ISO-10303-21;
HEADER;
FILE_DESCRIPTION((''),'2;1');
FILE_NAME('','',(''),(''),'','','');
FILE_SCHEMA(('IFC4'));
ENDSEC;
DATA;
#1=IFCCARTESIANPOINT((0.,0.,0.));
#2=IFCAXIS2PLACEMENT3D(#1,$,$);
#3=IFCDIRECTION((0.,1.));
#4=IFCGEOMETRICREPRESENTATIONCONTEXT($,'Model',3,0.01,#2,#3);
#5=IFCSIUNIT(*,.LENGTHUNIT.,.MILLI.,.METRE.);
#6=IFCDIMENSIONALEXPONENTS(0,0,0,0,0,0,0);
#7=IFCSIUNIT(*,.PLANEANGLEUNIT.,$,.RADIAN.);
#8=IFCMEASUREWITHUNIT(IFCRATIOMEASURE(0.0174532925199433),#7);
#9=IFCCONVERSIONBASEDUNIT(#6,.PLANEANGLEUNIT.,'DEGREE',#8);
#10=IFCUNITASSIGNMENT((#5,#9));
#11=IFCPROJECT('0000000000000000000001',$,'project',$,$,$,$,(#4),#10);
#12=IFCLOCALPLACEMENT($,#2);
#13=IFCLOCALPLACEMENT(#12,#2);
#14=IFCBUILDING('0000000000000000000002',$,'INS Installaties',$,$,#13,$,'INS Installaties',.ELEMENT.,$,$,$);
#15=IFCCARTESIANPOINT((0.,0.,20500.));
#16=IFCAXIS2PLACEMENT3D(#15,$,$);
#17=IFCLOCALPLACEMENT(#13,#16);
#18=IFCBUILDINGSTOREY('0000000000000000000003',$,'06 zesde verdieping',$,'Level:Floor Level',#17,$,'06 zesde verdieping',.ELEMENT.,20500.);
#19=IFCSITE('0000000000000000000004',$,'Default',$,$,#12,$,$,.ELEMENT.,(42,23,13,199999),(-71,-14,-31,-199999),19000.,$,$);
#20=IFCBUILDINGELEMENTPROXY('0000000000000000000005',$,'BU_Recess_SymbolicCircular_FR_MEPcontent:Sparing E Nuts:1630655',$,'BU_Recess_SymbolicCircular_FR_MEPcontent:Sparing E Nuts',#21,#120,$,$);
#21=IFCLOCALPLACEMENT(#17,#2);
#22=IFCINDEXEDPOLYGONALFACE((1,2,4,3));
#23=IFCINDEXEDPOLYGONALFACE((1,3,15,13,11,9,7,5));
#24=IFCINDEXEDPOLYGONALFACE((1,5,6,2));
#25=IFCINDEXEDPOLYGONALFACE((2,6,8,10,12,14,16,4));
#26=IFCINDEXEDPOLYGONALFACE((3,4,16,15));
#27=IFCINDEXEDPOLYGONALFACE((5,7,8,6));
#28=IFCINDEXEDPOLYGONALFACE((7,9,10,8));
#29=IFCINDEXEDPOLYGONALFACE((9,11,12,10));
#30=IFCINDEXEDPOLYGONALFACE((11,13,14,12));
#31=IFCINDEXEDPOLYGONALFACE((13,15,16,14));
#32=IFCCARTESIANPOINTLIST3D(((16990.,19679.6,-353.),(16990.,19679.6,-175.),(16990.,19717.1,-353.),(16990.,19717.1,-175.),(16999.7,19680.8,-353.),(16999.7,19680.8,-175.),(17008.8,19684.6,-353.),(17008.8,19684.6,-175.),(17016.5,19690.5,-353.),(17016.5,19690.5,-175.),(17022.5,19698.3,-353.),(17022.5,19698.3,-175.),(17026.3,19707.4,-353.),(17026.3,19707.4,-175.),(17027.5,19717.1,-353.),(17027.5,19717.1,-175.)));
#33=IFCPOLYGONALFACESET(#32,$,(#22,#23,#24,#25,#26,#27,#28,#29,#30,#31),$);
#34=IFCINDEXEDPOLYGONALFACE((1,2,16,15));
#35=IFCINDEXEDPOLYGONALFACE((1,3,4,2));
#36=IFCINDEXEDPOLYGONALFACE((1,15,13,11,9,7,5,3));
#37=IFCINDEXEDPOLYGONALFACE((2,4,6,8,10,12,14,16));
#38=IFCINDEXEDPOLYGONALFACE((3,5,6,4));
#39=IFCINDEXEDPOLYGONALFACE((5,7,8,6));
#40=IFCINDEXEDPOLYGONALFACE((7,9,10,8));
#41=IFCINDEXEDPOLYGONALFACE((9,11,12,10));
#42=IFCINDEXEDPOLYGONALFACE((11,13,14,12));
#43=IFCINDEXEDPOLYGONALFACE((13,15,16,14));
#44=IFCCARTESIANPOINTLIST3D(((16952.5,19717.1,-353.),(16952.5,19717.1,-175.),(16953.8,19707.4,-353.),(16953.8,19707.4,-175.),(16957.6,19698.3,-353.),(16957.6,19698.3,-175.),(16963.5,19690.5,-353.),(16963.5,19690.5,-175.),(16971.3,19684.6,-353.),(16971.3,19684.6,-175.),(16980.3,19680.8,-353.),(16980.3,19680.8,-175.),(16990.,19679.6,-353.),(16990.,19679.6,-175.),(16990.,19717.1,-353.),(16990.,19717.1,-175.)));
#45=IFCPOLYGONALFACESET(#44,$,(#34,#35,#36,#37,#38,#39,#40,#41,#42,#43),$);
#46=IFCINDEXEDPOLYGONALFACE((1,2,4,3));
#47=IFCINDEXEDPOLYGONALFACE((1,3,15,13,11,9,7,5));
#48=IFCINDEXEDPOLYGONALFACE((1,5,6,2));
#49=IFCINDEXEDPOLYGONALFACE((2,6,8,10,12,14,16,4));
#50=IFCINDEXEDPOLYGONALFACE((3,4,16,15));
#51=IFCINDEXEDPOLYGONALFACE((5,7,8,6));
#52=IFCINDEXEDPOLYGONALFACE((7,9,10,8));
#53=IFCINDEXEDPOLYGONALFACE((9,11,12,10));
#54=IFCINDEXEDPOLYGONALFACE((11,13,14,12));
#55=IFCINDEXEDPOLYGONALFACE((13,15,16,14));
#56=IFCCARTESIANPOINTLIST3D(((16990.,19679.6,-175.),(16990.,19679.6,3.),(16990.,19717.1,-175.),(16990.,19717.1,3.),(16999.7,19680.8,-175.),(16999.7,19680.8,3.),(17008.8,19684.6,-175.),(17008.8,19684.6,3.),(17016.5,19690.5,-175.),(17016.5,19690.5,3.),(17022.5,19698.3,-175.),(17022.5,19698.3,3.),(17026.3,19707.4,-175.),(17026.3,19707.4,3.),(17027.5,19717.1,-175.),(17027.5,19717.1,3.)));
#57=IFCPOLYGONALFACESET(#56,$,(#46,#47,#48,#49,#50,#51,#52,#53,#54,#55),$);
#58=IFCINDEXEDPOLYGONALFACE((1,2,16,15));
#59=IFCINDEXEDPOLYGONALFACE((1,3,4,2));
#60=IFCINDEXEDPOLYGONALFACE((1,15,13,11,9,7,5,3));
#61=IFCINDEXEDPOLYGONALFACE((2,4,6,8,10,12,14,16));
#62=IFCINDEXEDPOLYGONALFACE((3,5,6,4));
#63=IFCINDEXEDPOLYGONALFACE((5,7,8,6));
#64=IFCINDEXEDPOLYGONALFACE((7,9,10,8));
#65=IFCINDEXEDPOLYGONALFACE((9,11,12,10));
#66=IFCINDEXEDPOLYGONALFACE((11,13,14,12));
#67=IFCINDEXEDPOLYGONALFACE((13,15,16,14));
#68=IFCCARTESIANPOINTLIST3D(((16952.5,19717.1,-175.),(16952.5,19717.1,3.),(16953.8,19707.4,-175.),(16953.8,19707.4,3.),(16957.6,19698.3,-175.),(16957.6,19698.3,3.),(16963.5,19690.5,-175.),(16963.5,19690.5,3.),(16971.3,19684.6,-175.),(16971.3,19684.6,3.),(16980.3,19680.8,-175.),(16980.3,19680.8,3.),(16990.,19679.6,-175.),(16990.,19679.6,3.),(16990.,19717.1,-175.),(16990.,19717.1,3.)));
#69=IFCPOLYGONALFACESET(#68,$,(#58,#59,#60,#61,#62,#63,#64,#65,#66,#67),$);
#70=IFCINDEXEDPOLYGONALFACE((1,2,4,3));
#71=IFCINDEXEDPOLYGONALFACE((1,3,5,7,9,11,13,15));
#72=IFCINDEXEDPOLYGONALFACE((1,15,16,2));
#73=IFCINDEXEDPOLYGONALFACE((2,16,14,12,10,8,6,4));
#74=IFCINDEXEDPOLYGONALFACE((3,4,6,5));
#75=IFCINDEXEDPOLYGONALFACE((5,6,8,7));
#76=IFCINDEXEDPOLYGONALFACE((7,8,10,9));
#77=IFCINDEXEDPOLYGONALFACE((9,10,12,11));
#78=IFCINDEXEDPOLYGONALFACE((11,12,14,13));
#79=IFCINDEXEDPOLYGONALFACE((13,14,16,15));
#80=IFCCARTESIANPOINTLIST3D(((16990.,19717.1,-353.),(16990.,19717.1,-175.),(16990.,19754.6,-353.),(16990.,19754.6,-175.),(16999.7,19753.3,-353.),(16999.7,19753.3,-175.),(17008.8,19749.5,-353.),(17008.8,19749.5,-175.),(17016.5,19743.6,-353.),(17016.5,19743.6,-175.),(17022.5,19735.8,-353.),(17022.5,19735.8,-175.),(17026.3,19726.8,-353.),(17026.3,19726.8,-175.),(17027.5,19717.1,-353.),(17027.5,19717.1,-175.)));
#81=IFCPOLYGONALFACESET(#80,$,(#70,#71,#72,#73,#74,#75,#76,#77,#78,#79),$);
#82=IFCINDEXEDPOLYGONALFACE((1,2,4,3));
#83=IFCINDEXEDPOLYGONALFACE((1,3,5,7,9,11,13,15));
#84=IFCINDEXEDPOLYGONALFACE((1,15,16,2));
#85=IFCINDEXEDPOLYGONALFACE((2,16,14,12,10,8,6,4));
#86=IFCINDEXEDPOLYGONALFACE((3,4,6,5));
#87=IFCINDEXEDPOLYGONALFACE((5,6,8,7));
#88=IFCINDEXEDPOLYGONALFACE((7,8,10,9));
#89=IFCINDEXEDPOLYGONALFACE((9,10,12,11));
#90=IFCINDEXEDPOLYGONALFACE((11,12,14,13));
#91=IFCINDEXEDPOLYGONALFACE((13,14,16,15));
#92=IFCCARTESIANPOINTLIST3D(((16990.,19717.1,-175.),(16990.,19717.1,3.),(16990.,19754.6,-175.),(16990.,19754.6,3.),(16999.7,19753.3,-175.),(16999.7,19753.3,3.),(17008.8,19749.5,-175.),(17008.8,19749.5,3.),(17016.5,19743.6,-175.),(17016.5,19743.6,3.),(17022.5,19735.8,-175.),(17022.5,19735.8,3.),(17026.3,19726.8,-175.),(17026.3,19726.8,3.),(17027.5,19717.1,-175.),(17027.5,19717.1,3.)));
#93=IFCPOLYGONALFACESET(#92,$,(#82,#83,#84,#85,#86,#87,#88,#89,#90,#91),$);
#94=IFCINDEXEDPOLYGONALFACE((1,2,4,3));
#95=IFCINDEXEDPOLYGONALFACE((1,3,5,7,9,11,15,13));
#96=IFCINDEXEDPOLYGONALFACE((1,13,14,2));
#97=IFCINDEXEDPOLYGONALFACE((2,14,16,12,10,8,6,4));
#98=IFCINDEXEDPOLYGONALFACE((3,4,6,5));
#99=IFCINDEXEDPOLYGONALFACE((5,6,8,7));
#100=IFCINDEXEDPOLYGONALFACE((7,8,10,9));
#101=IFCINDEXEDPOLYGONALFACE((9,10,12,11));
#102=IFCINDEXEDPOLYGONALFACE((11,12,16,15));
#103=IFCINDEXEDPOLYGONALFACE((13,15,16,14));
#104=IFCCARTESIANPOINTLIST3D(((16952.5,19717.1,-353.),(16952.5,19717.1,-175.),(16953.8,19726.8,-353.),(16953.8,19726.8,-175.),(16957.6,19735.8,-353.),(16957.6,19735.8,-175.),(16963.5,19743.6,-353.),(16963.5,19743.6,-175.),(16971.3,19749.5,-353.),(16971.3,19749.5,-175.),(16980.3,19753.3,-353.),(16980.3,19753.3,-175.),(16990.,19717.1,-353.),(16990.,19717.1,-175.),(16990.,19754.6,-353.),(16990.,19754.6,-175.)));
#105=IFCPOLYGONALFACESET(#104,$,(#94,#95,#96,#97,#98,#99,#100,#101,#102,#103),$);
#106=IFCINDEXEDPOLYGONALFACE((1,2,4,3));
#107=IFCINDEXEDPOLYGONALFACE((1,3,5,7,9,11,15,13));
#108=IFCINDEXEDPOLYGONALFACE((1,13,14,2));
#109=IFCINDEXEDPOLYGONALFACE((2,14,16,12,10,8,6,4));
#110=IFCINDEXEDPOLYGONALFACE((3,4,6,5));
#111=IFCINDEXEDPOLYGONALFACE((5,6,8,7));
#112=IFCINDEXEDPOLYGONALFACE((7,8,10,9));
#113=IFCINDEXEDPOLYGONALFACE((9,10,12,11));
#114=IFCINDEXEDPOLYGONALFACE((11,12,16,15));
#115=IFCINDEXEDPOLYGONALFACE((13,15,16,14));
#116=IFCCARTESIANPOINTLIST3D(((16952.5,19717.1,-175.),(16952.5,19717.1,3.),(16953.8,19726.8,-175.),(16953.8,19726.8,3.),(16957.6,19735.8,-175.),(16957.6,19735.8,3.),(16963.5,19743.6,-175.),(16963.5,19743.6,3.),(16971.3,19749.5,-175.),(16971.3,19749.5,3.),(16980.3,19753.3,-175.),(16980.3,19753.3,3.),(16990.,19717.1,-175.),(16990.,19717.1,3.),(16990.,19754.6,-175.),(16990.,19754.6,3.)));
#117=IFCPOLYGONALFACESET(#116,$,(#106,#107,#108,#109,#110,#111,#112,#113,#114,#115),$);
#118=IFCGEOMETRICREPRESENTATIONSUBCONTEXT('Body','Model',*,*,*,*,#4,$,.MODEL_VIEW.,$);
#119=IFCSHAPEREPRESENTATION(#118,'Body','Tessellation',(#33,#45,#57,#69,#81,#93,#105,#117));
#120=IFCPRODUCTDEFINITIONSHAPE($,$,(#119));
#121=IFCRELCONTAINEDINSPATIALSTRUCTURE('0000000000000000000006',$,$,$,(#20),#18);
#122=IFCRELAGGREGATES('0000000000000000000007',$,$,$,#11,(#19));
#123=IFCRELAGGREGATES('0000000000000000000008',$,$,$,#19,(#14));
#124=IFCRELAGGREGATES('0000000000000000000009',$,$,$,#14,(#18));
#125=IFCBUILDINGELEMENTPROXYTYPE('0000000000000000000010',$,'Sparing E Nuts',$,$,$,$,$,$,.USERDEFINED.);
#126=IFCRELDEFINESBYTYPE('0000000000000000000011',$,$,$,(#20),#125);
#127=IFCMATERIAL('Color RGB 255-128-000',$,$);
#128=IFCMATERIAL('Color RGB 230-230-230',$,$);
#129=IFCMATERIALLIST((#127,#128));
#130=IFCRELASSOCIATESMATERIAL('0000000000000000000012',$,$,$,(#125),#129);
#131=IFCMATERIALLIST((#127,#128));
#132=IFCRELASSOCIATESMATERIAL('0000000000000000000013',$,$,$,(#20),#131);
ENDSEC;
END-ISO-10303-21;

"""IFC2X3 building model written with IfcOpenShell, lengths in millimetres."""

from ifc_helpers import new_model, entity, si_unit, converted_unit, direction, frame, frame_2d, origin, place, context, subcontext, project, spatial, polyline, circle_curve, parameter, trimmed, segment, composite_curve, outline, extrude, source, transform, mapped, material, material_list, type_object, type_shapes, element, save


model = new_model("IFC2X3")

# Units and contexts
model_context = context("Model", 3, precision=0.01, world=origin(), true_north=direction((0.0, 1.0)))
body_context = subcontext(model_context, "Body", "Model", "MODEL_VIEW")
ifc_project = project(units=[si_unit("LENGTHUNIT", "METRE", prefix="MILLI"), converted_unit("PLANEANGLEUNIT", "DEGREE", entity("IfcRatioMeasure", 0.0174532925199433), si_unit("PLANEANGLEUNIT", "RADIAN"), dimensions=[0, 0, 0, 0, 0, 0, 0])], contexts=[model_context])

# Site, building, storey
site_placement = place(None, origin())
site = spatial("IfcSite", under=ifc_project, at=site_placement, Name="Default", CompositionType="ELEMENT", RefLatitude=(42, 23, 13, 199999), RefLongitude=(-71, -14, -31, -199999), RefElevation=19000.0)
building_placement = place(site_placement, origin())
building = spatial("IfcBuilding", under=site, at=building_placement, Name="INS Installaties", LongName="INS Installaties", CompositionType="ELEMENT")
storey_placement = place(building_placement, frame((0.0, 0.0, 20500.0)))
storey = spatial("IfcBuildingStorey", under=building, at=storey_placement, Name="06 zesde verdieping", ObjectType="Level:Floor Level", LongName="06 zesde verdieping", CompositionType="ELEMENT", Elevation=20500.0)

# Building element proxy
ifc_material_1 = material(Name="Color RGB 255-128-000")
ifc_material_2 = material(Name="Color RGB 230-230-230")
ifc_material_list_1 = material_list([ifc_material_1, ifc_material_2])
ifc_material_list_2 = material_list([ifc_material_1, ifc_material_2])
building_element_proxy_type_1 = type_object("IfcBuildingElementProxyType", Name="Sparing E Nuts", PredefinedType="USERDEFINED", material=ifc_material_list_2)
shared_shape_1 = source(origin(), body_context, "Body", "SweptSolid", [
    extrude(outline(composite_curve([segment(polyline([(-25.0, -12.5), (12.5, -12.5)]), True, "CONTINUOUS"), segment(polyline([(12.5, -12.5), (12.5, 25.0)]), True, "CONTINUOUS"), segment(trimmed(circle_curve(frame_2d((12.5, -12.5), x_axis=(1.0, 0.0)), 37.5), [parameter(90.0)], [parameter(180.0)], True, "PARAMETER"), True, "CONTINUOUS")], self_intersect=False)), frame((12.5, -12.5, -353.0), z_axis=(0.0, 0.0, 1.0), x_axis=(-1.0, 0.0, 0.0)), (0.0, 0.0, 1.0), 178.0),
    extrude(outline(composite_curve([segment(trimmed(circle_curve(frame_2d((12.5, 12.5), x_axis=(1.0, 0.0)), 37.5), [parameter(180.0)], [parameter(270.0)], True, "PARAMETER"), True, "CONTINUOUS"), segment(polyline([(12.5, -25.0), (12.5, 12.5)]), True, "CONTINUOUS"), segment(polyline([(12.5, 12.5), (-25.0, 12.5)]), True, "CONTINUOUS")], self_intersect=False)), frame((-12.5, -12.5, -353.0)), (0.0, 0.0, 1.0), 178.0),
    extrude(outline(composite_curve([segment(polyline([(-25.0, -12.5), (12.5, -12.5)]), True, "CONTINUOUS"), segment(polyline([(12.5, -12.5), (12.5, 25.0)]), True, "CONTINUOUS"), segment(trimmed(circle_curve(frame_2d((12.5, -12.5), x_axis=(1.0, 0.0)), 37.5), [parameter(90.0)], [parameter(180.0)], True, "PARAMETER"), True, "CONTINUOUS")], self_intersect=False)), frame((12.5, -12.5, -175.0), z_axis=(0.0, 0.0, 1.0), x_axis=(-1.0, 0.0, 0.0)), (0.0, 0.0, 1.0), 178.0),
    extrude(outline(composite_curve([segment(trimmed(circle_curve(frame_2d((12.5, 12.5), x_axis=(1.0, 0.0)), 37.5), [parameter(180.0)], [parameter(270.0)], True, "PARAMETER"), True, "CONTINUOUS"), segment(polyline([(12.5, -25.0), (12.5, 12.5)]), True, "CONTINUOUS"), segment(polyline([(12.5, 12.5), (-25.0, 12.5)]), True, "CONTINUOUS")], self_intersect=False)), frame((-12.5, -12.5, -175.0)), (0.0, 0.0, 1.0), 178.0),
    extrude(outline(composite_curve([segment(trimmed(circle_curve(frame_2d((12.5, 12.5), x_axis=(1.0, 0.0)), 37.5), [parameter(180.0)], [parameter(270.0)], True, "PARAMETER"), True, "CONTINUOUS"), segment(polyline([(12.5, -25.0), (12.5, 12.5)]), True, "CONTINUOUS"), segment(polyline([(12.5, 12.5), (-25.0, 12.5)]), True, "CONTINUOUS")], self_intersect=False)), frame((12.5, 12.5, -353.0), z_axis=(0.0, 0.0, 1.0), x_axis=(-1.0, 0.0, 0.0)), (0.0, 0.0, 1.0), 178.0),
    extrude(outline(composite_curve([segment(trimmed(circle_curve(frame_2d((12.5, 12.5), x_axis=(1.0, 0.0)), 37.5), [parameter(180.0)], [parameter(270.0)], True, "PARAMETER"), True, "CONTINUOUS"), segment(polyline([(12.5, -25.0), (12.5, 12.5)]), True, "CONTINUOUS"), segment(polyline([(12.5, 12.5), (-25.0, 12.5)]), True, "CONTINUOUS")], self_intersect=False)), frame((12.5, 12.5, -175.0), z_axis=(0.0, 0.0, 1.0), x_axis=(-1.0, 0.0, 0.0)), (0.0, 0.0, 1.0), 178.0),
    extrude(outline(composite_curve([segment(polyline([(-25.0, -12.5), (12.5, -12.5)]), True, "CONTINUOUS"), segment(polyline([(12.5, -12.5), (12.5, 25.0)]), True, "CONTINUOUS"), segment(trimmed(circle_curve(frame_2d((12.5, -12.5), x_axis=(1.0, 0.0)), 37.5), [parameter(90.0)], [parameter(180.0)], True, "PARAMETER"), True, "CONTINUOUS")], self_intersect=False)), frame((-12.5, 12.5, -353.0)), (0.0, 0.0, 1.0), 178.0),
    extrude(outline(composite_curve([segment(polyline([(-25.0, -12.5), (12.5, -12.5)]), True, "CONTINUOUS"), segment(polyline([(12.5, -12.5), (12.5, 25.0)]), True, "CONTINUOUS"), segment(trimmed(circle_curve(frame_2d((12.5, -12.5), x_axis=(1.0, 0.0)), 37.5), [parameter(90.0)], [parameter(180.0)], True, "PARAMETER"), True, "CONTINUOUS")], self_intersect=False)), frame((-12.5, 12.5, -175.0)), (0.0, 0.0, 1.0), 178.0),
])
type_shapes(building_element_proxy_type_1, [shared_shape_1])
proxy_1_placement = place(storey_placement, frame((16990.0, 19717.1, 0.0)))
element("IfcBuildingElementProxy", 1, at=proxy_1_placement, inside=storey, type_object=building_element_proxy_type_1, material=ifc_material_list_1, Name="BU_Recess_SymbolicCircular_FR_MEPcontent:Sparing E Nuts:1630655", ObjectType="BU_Recess_SymbolicCircular_FR_MEPcontent:Sparing E Nuts", context=body_context, shape_type="MappedRepresentation", body=[
    mapped(shared_shape_1, transform((0.0, 0.0, 0.0), scale=1.0)),
])

save(model, "model.ifc")
